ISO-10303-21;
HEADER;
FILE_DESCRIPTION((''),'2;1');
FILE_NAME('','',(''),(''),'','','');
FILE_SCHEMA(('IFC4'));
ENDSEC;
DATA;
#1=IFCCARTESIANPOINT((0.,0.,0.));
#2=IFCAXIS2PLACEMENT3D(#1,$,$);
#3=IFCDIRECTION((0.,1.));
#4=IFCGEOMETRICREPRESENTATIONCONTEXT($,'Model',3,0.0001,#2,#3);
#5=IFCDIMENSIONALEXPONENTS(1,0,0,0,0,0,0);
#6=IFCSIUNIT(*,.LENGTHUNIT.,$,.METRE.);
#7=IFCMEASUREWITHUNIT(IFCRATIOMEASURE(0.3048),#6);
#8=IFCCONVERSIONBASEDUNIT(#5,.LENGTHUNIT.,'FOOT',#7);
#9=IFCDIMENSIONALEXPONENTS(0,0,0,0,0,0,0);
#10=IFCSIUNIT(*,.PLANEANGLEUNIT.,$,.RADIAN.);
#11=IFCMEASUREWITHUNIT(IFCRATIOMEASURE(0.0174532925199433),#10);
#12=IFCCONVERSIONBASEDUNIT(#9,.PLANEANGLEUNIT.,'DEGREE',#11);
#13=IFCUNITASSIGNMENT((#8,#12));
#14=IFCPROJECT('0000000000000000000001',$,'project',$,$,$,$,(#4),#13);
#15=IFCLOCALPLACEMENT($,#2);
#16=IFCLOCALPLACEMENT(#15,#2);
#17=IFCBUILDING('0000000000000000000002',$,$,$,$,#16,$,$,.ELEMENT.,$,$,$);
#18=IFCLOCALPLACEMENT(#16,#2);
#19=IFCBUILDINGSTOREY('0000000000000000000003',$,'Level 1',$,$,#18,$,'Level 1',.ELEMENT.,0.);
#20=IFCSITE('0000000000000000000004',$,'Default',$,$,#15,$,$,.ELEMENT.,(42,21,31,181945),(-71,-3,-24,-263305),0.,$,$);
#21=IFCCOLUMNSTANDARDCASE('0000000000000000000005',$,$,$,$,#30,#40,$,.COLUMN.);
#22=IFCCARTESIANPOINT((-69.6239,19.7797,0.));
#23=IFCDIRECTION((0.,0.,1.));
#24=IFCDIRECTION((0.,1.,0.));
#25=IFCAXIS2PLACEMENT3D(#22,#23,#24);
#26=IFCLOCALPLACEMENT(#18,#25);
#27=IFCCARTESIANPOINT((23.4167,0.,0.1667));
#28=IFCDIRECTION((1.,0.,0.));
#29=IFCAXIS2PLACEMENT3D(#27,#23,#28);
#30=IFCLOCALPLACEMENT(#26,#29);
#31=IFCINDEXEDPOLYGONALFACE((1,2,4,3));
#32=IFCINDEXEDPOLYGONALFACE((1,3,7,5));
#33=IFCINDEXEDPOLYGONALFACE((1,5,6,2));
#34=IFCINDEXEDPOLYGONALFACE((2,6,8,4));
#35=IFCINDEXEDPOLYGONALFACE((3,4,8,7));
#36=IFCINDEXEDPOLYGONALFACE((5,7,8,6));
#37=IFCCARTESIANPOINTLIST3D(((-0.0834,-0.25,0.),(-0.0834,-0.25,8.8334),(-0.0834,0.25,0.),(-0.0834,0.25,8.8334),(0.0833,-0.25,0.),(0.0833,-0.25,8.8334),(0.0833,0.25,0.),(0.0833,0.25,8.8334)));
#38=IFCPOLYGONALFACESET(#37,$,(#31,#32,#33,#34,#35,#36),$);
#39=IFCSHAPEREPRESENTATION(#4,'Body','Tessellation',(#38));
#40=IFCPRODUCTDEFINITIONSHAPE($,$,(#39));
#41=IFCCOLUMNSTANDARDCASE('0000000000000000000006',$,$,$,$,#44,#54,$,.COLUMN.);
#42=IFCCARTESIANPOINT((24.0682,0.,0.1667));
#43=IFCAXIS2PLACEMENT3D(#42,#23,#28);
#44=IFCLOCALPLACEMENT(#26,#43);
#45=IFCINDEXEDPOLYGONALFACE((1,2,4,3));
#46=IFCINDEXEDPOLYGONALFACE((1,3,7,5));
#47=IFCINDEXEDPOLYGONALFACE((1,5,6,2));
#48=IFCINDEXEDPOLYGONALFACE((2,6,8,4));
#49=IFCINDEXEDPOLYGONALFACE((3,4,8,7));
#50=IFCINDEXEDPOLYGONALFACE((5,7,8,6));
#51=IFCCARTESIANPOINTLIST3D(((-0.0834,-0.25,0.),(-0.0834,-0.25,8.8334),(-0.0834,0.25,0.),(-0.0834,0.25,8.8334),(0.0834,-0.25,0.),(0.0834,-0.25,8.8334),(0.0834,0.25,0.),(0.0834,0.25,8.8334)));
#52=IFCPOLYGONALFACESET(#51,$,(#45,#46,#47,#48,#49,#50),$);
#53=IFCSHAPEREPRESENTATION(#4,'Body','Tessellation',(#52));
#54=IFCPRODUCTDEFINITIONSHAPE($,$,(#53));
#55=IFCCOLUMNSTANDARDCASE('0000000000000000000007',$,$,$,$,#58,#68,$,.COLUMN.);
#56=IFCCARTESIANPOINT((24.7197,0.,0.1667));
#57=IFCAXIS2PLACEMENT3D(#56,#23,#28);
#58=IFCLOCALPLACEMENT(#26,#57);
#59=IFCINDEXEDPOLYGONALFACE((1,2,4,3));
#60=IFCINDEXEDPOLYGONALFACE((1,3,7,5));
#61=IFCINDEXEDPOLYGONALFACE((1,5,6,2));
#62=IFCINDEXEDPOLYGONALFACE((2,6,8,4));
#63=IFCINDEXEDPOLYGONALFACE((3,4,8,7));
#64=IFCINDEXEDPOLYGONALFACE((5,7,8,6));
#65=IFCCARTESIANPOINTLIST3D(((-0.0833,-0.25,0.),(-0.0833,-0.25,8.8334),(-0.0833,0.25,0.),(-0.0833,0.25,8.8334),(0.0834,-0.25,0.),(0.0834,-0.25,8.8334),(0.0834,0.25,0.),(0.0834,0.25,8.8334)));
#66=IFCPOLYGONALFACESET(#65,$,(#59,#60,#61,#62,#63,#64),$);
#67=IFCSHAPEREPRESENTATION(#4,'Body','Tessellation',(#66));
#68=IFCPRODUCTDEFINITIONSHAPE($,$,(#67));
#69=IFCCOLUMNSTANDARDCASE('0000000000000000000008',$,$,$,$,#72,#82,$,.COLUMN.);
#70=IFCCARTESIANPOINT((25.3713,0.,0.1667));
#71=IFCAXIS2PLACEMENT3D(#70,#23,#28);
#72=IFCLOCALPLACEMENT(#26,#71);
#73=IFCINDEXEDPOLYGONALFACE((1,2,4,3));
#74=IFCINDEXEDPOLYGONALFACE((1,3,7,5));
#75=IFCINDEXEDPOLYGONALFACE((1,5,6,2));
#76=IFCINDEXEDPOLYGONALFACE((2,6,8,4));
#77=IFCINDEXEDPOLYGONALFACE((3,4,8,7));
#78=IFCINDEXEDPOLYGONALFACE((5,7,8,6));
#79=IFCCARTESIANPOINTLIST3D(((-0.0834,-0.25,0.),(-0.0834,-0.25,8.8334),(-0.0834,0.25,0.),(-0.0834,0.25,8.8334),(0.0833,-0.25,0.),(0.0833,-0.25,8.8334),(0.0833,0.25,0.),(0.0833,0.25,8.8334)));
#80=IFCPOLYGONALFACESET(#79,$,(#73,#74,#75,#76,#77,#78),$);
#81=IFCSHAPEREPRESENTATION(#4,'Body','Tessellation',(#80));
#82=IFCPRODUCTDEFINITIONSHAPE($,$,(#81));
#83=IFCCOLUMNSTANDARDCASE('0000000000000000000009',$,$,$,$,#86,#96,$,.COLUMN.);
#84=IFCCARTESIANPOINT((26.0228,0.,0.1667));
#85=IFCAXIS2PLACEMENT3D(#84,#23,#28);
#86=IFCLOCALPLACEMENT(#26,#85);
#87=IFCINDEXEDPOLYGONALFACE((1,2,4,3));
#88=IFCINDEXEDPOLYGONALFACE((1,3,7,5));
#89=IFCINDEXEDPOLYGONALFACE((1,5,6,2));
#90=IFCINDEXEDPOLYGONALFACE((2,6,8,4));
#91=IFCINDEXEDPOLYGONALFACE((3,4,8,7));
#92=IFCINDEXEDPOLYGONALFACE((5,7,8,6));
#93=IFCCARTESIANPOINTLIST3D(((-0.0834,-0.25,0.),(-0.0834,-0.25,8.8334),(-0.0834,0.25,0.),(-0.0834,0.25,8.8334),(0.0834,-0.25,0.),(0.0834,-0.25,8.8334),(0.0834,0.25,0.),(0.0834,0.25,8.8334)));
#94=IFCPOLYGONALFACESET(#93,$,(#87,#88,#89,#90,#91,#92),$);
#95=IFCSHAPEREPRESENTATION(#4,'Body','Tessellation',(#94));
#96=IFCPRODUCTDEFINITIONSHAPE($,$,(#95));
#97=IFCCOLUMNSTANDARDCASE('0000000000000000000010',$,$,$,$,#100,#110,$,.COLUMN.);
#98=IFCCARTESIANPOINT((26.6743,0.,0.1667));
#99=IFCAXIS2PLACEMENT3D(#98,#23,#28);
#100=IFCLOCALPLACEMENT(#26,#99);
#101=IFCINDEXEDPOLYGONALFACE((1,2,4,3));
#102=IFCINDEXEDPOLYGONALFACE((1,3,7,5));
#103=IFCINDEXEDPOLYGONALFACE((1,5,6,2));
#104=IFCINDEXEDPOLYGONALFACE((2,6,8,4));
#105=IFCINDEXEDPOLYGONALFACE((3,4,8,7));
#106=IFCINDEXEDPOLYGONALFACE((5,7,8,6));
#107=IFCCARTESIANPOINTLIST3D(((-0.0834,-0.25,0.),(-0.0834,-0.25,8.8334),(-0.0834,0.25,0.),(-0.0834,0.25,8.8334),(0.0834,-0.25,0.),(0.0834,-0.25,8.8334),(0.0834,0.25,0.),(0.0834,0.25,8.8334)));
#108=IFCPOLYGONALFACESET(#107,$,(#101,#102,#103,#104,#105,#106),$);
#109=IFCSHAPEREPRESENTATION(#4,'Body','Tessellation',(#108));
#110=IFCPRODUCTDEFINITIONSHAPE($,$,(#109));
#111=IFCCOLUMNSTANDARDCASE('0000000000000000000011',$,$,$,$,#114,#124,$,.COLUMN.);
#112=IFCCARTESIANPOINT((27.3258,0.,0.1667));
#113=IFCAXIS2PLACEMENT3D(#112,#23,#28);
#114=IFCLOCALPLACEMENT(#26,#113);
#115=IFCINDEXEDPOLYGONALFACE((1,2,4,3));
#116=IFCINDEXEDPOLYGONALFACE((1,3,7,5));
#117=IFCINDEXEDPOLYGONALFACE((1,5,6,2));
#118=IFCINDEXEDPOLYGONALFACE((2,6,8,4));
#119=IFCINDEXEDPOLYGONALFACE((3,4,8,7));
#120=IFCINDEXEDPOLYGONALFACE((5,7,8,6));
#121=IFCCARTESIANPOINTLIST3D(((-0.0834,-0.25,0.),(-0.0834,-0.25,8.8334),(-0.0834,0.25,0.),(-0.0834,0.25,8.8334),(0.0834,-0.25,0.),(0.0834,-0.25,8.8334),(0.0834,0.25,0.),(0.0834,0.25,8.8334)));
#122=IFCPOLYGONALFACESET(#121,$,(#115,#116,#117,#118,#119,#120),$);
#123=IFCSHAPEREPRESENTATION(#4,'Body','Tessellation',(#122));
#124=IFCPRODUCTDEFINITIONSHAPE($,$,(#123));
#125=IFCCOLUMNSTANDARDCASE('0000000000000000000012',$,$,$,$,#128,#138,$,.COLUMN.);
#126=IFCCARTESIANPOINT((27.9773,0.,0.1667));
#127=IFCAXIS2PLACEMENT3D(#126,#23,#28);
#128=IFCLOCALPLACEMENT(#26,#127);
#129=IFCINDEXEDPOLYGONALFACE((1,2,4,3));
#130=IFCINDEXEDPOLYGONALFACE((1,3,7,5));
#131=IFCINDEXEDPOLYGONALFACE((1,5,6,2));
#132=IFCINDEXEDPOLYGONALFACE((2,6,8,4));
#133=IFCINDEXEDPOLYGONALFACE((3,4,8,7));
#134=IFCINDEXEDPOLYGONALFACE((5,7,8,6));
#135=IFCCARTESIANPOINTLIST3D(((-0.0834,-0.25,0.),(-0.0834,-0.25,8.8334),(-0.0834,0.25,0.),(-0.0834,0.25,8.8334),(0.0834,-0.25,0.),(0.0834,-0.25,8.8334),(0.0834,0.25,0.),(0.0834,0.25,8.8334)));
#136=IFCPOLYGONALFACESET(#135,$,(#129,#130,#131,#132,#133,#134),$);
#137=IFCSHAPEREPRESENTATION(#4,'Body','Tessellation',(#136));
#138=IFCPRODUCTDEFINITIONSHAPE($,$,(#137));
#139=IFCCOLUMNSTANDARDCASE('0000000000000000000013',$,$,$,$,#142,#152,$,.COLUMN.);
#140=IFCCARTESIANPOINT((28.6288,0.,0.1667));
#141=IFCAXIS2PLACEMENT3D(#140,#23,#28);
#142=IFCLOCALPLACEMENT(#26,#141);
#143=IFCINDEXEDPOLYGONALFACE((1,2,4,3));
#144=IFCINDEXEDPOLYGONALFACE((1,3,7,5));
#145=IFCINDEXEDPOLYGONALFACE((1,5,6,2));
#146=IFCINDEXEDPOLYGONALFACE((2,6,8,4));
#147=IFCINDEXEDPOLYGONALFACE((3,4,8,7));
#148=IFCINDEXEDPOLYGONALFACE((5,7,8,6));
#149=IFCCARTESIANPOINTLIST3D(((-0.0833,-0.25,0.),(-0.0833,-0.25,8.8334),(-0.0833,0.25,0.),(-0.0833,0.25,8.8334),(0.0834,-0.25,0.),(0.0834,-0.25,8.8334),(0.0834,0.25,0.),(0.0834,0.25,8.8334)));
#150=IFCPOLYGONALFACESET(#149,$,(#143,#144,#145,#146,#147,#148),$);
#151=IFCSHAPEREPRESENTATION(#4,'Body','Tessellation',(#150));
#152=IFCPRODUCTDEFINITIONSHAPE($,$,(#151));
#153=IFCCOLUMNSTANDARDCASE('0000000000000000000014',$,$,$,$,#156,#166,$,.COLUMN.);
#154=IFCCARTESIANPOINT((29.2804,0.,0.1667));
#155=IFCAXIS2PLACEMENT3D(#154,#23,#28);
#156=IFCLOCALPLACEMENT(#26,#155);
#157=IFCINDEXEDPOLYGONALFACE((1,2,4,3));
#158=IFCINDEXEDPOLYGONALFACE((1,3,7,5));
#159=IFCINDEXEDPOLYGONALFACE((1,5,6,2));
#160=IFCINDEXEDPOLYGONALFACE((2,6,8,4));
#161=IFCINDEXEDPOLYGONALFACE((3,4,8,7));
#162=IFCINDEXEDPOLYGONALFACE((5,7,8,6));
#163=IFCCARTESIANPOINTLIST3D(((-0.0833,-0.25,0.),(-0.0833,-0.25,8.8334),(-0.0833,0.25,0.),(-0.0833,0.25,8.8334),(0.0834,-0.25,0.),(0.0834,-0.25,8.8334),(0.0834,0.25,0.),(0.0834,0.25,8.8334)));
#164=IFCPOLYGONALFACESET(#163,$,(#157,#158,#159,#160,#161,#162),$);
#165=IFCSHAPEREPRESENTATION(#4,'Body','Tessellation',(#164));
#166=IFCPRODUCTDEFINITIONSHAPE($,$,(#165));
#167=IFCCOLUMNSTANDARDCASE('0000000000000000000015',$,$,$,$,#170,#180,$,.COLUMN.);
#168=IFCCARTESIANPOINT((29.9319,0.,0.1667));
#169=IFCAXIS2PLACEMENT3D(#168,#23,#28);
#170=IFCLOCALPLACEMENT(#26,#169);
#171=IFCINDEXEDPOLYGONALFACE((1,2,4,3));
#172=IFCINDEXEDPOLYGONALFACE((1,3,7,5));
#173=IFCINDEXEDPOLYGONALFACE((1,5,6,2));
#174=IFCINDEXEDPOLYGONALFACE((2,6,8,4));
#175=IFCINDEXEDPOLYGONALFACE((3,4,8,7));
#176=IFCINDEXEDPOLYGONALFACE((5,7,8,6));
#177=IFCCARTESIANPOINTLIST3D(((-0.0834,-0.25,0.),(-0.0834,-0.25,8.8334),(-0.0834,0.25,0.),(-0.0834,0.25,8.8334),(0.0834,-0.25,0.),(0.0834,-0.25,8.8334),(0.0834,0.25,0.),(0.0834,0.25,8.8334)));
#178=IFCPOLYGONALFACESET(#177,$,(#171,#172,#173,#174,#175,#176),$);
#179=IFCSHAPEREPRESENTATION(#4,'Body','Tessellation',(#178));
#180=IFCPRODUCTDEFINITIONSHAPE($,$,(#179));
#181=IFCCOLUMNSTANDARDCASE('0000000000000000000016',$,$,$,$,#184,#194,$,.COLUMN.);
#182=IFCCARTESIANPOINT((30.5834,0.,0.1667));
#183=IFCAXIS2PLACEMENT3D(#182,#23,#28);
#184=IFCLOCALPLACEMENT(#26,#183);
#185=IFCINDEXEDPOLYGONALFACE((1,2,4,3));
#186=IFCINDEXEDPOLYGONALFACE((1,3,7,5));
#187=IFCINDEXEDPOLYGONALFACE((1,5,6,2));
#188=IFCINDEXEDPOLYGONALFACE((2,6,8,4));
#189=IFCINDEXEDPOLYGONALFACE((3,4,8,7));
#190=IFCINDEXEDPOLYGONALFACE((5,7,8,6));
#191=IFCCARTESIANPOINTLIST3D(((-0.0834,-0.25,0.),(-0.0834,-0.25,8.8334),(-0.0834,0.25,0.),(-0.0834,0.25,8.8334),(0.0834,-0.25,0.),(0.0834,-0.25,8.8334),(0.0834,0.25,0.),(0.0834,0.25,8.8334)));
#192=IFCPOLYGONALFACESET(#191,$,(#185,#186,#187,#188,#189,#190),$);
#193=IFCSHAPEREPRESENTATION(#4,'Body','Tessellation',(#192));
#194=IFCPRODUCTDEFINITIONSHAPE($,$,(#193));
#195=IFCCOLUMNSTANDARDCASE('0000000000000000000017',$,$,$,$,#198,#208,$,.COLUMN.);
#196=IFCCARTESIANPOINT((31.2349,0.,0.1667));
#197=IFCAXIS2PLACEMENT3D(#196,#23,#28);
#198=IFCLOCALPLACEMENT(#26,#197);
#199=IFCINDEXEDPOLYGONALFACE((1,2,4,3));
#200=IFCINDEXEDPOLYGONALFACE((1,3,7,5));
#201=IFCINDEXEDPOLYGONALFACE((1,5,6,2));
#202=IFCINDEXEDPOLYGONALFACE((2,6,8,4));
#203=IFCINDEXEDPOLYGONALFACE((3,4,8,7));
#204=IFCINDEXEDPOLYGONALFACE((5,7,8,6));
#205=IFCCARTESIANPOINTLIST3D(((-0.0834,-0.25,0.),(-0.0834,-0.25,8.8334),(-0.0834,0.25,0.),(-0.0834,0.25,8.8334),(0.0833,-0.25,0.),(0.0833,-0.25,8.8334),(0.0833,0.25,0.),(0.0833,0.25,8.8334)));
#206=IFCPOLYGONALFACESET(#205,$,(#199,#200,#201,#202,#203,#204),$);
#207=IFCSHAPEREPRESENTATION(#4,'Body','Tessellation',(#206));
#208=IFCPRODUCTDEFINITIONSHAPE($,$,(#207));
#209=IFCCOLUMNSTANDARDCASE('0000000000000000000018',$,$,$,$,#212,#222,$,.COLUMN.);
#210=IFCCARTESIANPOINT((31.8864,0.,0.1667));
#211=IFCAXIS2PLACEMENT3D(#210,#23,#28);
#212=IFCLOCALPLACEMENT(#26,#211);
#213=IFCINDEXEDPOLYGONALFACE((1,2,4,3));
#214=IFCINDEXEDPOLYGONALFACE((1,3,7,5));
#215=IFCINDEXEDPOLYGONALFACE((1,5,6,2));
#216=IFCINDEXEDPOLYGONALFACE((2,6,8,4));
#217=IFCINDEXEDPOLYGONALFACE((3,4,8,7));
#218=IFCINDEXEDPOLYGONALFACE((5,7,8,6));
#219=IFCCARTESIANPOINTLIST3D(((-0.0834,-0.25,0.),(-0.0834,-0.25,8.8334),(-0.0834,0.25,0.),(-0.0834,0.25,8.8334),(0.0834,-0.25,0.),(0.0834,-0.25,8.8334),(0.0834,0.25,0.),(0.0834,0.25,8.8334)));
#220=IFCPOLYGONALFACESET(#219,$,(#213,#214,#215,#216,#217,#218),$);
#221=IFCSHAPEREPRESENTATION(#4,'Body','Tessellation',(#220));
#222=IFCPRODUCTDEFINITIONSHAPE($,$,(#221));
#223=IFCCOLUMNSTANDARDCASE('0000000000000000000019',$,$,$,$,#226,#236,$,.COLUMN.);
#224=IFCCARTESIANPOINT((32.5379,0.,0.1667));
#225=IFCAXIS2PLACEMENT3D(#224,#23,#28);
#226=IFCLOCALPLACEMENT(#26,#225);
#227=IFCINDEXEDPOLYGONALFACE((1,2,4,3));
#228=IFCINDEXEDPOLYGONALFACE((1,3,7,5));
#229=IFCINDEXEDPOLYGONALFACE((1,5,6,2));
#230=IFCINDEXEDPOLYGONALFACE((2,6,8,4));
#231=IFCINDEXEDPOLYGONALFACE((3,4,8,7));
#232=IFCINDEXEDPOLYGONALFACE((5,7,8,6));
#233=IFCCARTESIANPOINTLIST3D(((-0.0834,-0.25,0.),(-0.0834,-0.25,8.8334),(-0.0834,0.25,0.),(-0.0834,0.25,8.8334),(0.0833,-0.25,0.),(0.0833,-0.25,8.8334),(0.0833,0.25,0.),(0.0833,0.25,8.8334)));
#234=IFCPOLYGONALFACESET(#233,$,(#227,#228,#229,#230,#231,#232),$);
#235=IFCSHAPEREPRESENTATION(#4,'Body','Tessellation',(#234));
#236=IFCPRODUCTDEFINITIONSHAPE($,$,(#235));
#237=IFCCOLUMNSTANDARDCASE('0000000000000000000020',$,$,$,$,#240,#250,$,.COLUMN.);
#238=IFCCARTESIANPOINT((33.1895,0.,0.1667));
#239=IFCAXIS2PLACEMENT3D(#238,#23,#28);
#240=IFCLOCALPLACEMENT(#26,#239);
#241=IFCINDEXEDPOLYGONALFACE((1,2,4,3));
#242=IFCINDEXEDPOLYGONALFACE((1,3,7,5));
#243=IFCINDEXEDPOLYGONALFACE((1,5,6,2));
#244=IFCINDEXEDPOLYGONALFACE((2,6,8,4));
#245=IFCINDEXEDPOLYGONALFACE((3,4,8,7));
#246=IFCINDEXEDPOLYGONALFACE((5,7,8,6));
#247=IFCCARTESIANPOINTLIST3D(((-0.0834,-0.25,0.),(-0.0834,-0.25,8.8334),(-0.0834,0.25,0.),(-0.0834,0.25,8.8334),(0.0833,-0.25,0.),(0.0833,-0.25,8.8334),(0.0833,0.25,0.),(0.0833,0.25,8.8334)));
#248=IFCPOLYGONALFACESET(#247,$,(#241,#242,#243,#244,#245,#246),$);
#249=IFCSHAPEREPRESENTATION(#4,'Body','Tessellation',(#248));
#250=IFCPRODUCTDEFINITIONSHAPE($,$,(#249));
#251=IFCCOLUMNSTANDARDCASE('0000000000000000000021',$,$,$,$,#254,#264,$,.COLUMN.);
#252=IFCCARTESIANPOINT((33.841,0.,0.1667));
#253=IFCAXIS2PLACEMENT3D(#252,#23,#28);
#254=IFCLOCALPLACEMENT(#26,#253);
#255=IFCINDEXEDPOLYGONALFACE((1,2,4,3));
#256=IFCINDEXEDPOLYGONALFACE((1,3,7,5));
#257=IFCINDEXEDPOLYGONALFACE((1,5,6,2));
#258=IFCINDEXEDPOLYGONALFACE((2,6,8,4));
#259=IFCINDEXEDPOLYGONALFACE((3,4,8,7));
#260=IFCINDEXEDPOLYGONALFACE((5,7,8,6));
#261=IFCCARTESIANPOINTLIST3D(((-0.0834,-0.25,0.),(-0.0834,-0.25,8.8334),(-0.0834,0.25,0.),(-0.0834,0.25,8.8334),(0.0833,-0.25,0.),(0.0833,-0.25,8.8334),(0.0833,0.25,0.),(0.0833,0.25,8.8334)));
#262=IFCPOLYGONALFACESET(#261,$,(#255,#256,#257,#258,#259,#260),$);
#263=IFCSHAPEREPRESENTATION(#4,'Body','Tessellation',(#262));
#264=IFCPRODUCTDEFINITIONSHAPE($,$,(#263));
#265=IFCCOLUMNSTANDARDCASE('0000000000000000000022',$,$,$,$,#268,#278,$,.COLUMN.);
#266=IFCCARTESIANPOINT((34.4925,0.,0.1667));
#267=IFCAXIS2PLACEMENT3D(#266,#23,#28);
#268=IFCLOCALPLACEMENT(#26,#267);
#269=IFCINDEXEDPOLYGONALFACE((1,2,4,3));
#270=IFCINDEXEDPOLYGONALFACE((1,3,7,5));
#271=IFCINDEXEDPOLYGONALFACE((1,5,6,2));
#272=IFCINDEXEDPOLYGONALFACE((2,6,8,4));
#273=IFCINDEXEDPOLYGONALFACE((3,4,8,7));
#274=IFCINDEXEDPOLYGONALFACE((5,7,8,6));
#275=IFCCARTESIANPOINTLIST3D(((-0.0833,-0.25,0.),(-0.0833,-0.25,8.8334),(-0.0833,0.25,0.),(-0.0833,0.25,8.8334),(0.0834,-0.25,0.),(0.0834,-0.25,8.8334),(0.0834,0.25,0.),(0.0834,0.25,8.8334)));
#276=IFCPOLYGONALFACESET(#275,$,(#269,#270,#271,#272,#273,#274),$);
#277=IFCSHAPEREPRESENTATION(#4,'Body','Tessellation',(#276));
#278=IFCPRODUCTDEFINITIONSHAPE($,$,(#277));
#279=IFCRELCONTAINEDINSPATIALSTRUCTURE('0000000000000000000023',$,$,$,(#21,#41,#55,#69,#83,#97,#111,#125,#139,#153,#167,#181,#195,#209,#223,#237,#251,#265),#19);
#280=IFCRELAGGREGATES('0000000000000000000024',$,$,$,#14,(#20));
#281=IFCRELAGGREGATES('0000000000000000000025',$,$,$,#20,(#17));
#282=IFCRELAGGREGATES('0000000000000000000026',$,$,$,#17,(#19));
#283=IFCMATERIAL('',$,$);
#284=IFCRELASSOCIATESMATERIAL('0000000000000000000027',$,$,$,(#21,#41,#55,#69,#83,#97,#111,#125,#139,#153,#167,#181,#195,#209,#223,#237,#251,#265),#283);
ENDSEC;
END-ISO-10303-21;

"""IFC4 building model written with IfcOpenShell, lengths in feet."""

from ifc_helpers import new_model, entity, si_unit, converted_unit, direction, frame, origin, place, context, project, spatial, rectangle, extrude, material, element, save


model = new_model("IFC4")

# Units and contexts
model_context = context("Model", 3, precision=0.0001, world=origin(), true_north=direction((0.0, 1.0)))
ifc_project = project(units=[converted_unit("LENGTHUNIT", "FOOT", entity("IfcRatioMeasure", 0.3048), si_unit("LENGTHUNIT", "METRE"), dimensions=[1, 0, 0, 0, 0, 0, 0]), converted_unit("PLANEANGLEUNIT", "DEGREE", entity("IfcRatioMeasure", 0.0174532925199433), si_unit("PLANEANGLEUNIT", "RADIAN"), dimensions=[0, 0, 0, 0, 0, 0, 0])], contexts=[model_context])

# Site, building, storey
site_placement = place(None, origin())
site = spatial("IfcSite", under=ifc_project, at=site_placement, Name="Default", CompositionType="ELEMENT", RefLatitude=(42, 21, 31, 181945), RefLongitude=(-71, -3, -24, -263305), RefElevation=0.0)
building_placement = place(site_placement, origin())
building = spatial("IfcBuilding", under=site, at=building_placement, CompositionType="ELEMENT")
storey_placement = place(building_placement, origin())
storey = spatial("IfcBuildingStorey", under=building, at=storey_placement, Name="Level 1", LongName="Level 1", CompositionType="ELEMENT", Elevation=0.0)

# Columns
ifc_material_1 = material(Name="")
placement_1 = place(storey_placement, frame((-69.6239, 19.7797, 0.0), z_axis=(0.0, 0.0, 1.0), x_axis=(0.0, 1.0, 0.0)))
for number, where, z_axis, x_axis in (
    (1, (23.4167, 0.0, 0.1667), (0.0, 0.0, 1.0), (1.0, 0.0, 0.0)),
    (2, (24.0682, 0.0, 0.1667), (0.0, 0.0, 1.0), (1.0, 0.0, 0.0)),
    (3, (24.7197, 0.0, 0.1667), (0.0, 0.0, 1.0), (1.0, 0.0, 0.0)),
    (4, (25.3713, 0.0, 0.1667), (0.0, 0.0, 1.0), (1.0, 0.0, 0.0)),
    (5, (26.0228, 0.0, 0.1667), (0.0, 0.0, 1.0), (1.0, 0.0, 0.0)),
    (6, (26.6743, 0.0, 0.1667), (0.0, 0.0, 1.0), (1.0, 0.0, 0.0)),
    (7, (27.3258, 0.0, 0.1667), (0.0, 0.0, 1.0), (1.0, 0.0, 0.0)),
    (8, (27.9773, 0.0, 0.1667), (0.0, 0.0, 1.0), (1.0, 0.0, 0.0)),
    (9, (28.6288, 0.0, 0.1667), (0.0, 0.0, 1.0), (1.0, 0.0, 0.0)),
    (10, (29.2804, 0.0, 0.1667), (0.0, 0.0, 1.0), (1.0, 0.0, 0.0)),
    (11, (29.9319, 0.0, 0.1667), (0.0, 0.0, 1.0), (1.0, 0.0, 0.0)),
    (12, (30.5834, 0.0, 0.1667), (0.0, 0.0, 1.0), (1.0, 0.0, 0.0)),
    (13, (31.2349, 0.0, 0.1667), (0.0, 0.0, 1.0), (1.0, 0.0, 0.0)),
    (14, (31.8864, 0.0, 0.1667), (0.0, 0.0, 1.0), (1.0, 0.0, 0.0)),
    (15, (32.5379, 0.0, 0.1667), (0.0, 0.0, 1.0), (1.0, 0.0, 0.0)),
    (16, (33.1895, 0.0, 0.1667), (0.0, 0.0, 1.0), (1.0, 0.0, 0.0)),
    (17, (33.841, 0.0, 0.1667), (0.0, 0.0, 1.0), (1.0, 0.0, 0.0)),
    (18, (34.4925, 0.0, 0.1667), (0.0, 0.0, 1.0), (1.0, 0.0, 0.0)),
):
    element("IfcColumnStandardCase", number, at=place(placement_1, frame(where, z_axis=z_axis, x_axis=x_axis)), inside=storey, material=ifc_material_1, PredefinedType="COLUMN", context=model_context, shape_type="SweptSolid", body=[
        extrude(rectangle(XDim=0.1667, YDim=0.5), origin(), (0.0, 0.0, 1.0), 8.8334),
    ])

save(model, "model.ifc")
